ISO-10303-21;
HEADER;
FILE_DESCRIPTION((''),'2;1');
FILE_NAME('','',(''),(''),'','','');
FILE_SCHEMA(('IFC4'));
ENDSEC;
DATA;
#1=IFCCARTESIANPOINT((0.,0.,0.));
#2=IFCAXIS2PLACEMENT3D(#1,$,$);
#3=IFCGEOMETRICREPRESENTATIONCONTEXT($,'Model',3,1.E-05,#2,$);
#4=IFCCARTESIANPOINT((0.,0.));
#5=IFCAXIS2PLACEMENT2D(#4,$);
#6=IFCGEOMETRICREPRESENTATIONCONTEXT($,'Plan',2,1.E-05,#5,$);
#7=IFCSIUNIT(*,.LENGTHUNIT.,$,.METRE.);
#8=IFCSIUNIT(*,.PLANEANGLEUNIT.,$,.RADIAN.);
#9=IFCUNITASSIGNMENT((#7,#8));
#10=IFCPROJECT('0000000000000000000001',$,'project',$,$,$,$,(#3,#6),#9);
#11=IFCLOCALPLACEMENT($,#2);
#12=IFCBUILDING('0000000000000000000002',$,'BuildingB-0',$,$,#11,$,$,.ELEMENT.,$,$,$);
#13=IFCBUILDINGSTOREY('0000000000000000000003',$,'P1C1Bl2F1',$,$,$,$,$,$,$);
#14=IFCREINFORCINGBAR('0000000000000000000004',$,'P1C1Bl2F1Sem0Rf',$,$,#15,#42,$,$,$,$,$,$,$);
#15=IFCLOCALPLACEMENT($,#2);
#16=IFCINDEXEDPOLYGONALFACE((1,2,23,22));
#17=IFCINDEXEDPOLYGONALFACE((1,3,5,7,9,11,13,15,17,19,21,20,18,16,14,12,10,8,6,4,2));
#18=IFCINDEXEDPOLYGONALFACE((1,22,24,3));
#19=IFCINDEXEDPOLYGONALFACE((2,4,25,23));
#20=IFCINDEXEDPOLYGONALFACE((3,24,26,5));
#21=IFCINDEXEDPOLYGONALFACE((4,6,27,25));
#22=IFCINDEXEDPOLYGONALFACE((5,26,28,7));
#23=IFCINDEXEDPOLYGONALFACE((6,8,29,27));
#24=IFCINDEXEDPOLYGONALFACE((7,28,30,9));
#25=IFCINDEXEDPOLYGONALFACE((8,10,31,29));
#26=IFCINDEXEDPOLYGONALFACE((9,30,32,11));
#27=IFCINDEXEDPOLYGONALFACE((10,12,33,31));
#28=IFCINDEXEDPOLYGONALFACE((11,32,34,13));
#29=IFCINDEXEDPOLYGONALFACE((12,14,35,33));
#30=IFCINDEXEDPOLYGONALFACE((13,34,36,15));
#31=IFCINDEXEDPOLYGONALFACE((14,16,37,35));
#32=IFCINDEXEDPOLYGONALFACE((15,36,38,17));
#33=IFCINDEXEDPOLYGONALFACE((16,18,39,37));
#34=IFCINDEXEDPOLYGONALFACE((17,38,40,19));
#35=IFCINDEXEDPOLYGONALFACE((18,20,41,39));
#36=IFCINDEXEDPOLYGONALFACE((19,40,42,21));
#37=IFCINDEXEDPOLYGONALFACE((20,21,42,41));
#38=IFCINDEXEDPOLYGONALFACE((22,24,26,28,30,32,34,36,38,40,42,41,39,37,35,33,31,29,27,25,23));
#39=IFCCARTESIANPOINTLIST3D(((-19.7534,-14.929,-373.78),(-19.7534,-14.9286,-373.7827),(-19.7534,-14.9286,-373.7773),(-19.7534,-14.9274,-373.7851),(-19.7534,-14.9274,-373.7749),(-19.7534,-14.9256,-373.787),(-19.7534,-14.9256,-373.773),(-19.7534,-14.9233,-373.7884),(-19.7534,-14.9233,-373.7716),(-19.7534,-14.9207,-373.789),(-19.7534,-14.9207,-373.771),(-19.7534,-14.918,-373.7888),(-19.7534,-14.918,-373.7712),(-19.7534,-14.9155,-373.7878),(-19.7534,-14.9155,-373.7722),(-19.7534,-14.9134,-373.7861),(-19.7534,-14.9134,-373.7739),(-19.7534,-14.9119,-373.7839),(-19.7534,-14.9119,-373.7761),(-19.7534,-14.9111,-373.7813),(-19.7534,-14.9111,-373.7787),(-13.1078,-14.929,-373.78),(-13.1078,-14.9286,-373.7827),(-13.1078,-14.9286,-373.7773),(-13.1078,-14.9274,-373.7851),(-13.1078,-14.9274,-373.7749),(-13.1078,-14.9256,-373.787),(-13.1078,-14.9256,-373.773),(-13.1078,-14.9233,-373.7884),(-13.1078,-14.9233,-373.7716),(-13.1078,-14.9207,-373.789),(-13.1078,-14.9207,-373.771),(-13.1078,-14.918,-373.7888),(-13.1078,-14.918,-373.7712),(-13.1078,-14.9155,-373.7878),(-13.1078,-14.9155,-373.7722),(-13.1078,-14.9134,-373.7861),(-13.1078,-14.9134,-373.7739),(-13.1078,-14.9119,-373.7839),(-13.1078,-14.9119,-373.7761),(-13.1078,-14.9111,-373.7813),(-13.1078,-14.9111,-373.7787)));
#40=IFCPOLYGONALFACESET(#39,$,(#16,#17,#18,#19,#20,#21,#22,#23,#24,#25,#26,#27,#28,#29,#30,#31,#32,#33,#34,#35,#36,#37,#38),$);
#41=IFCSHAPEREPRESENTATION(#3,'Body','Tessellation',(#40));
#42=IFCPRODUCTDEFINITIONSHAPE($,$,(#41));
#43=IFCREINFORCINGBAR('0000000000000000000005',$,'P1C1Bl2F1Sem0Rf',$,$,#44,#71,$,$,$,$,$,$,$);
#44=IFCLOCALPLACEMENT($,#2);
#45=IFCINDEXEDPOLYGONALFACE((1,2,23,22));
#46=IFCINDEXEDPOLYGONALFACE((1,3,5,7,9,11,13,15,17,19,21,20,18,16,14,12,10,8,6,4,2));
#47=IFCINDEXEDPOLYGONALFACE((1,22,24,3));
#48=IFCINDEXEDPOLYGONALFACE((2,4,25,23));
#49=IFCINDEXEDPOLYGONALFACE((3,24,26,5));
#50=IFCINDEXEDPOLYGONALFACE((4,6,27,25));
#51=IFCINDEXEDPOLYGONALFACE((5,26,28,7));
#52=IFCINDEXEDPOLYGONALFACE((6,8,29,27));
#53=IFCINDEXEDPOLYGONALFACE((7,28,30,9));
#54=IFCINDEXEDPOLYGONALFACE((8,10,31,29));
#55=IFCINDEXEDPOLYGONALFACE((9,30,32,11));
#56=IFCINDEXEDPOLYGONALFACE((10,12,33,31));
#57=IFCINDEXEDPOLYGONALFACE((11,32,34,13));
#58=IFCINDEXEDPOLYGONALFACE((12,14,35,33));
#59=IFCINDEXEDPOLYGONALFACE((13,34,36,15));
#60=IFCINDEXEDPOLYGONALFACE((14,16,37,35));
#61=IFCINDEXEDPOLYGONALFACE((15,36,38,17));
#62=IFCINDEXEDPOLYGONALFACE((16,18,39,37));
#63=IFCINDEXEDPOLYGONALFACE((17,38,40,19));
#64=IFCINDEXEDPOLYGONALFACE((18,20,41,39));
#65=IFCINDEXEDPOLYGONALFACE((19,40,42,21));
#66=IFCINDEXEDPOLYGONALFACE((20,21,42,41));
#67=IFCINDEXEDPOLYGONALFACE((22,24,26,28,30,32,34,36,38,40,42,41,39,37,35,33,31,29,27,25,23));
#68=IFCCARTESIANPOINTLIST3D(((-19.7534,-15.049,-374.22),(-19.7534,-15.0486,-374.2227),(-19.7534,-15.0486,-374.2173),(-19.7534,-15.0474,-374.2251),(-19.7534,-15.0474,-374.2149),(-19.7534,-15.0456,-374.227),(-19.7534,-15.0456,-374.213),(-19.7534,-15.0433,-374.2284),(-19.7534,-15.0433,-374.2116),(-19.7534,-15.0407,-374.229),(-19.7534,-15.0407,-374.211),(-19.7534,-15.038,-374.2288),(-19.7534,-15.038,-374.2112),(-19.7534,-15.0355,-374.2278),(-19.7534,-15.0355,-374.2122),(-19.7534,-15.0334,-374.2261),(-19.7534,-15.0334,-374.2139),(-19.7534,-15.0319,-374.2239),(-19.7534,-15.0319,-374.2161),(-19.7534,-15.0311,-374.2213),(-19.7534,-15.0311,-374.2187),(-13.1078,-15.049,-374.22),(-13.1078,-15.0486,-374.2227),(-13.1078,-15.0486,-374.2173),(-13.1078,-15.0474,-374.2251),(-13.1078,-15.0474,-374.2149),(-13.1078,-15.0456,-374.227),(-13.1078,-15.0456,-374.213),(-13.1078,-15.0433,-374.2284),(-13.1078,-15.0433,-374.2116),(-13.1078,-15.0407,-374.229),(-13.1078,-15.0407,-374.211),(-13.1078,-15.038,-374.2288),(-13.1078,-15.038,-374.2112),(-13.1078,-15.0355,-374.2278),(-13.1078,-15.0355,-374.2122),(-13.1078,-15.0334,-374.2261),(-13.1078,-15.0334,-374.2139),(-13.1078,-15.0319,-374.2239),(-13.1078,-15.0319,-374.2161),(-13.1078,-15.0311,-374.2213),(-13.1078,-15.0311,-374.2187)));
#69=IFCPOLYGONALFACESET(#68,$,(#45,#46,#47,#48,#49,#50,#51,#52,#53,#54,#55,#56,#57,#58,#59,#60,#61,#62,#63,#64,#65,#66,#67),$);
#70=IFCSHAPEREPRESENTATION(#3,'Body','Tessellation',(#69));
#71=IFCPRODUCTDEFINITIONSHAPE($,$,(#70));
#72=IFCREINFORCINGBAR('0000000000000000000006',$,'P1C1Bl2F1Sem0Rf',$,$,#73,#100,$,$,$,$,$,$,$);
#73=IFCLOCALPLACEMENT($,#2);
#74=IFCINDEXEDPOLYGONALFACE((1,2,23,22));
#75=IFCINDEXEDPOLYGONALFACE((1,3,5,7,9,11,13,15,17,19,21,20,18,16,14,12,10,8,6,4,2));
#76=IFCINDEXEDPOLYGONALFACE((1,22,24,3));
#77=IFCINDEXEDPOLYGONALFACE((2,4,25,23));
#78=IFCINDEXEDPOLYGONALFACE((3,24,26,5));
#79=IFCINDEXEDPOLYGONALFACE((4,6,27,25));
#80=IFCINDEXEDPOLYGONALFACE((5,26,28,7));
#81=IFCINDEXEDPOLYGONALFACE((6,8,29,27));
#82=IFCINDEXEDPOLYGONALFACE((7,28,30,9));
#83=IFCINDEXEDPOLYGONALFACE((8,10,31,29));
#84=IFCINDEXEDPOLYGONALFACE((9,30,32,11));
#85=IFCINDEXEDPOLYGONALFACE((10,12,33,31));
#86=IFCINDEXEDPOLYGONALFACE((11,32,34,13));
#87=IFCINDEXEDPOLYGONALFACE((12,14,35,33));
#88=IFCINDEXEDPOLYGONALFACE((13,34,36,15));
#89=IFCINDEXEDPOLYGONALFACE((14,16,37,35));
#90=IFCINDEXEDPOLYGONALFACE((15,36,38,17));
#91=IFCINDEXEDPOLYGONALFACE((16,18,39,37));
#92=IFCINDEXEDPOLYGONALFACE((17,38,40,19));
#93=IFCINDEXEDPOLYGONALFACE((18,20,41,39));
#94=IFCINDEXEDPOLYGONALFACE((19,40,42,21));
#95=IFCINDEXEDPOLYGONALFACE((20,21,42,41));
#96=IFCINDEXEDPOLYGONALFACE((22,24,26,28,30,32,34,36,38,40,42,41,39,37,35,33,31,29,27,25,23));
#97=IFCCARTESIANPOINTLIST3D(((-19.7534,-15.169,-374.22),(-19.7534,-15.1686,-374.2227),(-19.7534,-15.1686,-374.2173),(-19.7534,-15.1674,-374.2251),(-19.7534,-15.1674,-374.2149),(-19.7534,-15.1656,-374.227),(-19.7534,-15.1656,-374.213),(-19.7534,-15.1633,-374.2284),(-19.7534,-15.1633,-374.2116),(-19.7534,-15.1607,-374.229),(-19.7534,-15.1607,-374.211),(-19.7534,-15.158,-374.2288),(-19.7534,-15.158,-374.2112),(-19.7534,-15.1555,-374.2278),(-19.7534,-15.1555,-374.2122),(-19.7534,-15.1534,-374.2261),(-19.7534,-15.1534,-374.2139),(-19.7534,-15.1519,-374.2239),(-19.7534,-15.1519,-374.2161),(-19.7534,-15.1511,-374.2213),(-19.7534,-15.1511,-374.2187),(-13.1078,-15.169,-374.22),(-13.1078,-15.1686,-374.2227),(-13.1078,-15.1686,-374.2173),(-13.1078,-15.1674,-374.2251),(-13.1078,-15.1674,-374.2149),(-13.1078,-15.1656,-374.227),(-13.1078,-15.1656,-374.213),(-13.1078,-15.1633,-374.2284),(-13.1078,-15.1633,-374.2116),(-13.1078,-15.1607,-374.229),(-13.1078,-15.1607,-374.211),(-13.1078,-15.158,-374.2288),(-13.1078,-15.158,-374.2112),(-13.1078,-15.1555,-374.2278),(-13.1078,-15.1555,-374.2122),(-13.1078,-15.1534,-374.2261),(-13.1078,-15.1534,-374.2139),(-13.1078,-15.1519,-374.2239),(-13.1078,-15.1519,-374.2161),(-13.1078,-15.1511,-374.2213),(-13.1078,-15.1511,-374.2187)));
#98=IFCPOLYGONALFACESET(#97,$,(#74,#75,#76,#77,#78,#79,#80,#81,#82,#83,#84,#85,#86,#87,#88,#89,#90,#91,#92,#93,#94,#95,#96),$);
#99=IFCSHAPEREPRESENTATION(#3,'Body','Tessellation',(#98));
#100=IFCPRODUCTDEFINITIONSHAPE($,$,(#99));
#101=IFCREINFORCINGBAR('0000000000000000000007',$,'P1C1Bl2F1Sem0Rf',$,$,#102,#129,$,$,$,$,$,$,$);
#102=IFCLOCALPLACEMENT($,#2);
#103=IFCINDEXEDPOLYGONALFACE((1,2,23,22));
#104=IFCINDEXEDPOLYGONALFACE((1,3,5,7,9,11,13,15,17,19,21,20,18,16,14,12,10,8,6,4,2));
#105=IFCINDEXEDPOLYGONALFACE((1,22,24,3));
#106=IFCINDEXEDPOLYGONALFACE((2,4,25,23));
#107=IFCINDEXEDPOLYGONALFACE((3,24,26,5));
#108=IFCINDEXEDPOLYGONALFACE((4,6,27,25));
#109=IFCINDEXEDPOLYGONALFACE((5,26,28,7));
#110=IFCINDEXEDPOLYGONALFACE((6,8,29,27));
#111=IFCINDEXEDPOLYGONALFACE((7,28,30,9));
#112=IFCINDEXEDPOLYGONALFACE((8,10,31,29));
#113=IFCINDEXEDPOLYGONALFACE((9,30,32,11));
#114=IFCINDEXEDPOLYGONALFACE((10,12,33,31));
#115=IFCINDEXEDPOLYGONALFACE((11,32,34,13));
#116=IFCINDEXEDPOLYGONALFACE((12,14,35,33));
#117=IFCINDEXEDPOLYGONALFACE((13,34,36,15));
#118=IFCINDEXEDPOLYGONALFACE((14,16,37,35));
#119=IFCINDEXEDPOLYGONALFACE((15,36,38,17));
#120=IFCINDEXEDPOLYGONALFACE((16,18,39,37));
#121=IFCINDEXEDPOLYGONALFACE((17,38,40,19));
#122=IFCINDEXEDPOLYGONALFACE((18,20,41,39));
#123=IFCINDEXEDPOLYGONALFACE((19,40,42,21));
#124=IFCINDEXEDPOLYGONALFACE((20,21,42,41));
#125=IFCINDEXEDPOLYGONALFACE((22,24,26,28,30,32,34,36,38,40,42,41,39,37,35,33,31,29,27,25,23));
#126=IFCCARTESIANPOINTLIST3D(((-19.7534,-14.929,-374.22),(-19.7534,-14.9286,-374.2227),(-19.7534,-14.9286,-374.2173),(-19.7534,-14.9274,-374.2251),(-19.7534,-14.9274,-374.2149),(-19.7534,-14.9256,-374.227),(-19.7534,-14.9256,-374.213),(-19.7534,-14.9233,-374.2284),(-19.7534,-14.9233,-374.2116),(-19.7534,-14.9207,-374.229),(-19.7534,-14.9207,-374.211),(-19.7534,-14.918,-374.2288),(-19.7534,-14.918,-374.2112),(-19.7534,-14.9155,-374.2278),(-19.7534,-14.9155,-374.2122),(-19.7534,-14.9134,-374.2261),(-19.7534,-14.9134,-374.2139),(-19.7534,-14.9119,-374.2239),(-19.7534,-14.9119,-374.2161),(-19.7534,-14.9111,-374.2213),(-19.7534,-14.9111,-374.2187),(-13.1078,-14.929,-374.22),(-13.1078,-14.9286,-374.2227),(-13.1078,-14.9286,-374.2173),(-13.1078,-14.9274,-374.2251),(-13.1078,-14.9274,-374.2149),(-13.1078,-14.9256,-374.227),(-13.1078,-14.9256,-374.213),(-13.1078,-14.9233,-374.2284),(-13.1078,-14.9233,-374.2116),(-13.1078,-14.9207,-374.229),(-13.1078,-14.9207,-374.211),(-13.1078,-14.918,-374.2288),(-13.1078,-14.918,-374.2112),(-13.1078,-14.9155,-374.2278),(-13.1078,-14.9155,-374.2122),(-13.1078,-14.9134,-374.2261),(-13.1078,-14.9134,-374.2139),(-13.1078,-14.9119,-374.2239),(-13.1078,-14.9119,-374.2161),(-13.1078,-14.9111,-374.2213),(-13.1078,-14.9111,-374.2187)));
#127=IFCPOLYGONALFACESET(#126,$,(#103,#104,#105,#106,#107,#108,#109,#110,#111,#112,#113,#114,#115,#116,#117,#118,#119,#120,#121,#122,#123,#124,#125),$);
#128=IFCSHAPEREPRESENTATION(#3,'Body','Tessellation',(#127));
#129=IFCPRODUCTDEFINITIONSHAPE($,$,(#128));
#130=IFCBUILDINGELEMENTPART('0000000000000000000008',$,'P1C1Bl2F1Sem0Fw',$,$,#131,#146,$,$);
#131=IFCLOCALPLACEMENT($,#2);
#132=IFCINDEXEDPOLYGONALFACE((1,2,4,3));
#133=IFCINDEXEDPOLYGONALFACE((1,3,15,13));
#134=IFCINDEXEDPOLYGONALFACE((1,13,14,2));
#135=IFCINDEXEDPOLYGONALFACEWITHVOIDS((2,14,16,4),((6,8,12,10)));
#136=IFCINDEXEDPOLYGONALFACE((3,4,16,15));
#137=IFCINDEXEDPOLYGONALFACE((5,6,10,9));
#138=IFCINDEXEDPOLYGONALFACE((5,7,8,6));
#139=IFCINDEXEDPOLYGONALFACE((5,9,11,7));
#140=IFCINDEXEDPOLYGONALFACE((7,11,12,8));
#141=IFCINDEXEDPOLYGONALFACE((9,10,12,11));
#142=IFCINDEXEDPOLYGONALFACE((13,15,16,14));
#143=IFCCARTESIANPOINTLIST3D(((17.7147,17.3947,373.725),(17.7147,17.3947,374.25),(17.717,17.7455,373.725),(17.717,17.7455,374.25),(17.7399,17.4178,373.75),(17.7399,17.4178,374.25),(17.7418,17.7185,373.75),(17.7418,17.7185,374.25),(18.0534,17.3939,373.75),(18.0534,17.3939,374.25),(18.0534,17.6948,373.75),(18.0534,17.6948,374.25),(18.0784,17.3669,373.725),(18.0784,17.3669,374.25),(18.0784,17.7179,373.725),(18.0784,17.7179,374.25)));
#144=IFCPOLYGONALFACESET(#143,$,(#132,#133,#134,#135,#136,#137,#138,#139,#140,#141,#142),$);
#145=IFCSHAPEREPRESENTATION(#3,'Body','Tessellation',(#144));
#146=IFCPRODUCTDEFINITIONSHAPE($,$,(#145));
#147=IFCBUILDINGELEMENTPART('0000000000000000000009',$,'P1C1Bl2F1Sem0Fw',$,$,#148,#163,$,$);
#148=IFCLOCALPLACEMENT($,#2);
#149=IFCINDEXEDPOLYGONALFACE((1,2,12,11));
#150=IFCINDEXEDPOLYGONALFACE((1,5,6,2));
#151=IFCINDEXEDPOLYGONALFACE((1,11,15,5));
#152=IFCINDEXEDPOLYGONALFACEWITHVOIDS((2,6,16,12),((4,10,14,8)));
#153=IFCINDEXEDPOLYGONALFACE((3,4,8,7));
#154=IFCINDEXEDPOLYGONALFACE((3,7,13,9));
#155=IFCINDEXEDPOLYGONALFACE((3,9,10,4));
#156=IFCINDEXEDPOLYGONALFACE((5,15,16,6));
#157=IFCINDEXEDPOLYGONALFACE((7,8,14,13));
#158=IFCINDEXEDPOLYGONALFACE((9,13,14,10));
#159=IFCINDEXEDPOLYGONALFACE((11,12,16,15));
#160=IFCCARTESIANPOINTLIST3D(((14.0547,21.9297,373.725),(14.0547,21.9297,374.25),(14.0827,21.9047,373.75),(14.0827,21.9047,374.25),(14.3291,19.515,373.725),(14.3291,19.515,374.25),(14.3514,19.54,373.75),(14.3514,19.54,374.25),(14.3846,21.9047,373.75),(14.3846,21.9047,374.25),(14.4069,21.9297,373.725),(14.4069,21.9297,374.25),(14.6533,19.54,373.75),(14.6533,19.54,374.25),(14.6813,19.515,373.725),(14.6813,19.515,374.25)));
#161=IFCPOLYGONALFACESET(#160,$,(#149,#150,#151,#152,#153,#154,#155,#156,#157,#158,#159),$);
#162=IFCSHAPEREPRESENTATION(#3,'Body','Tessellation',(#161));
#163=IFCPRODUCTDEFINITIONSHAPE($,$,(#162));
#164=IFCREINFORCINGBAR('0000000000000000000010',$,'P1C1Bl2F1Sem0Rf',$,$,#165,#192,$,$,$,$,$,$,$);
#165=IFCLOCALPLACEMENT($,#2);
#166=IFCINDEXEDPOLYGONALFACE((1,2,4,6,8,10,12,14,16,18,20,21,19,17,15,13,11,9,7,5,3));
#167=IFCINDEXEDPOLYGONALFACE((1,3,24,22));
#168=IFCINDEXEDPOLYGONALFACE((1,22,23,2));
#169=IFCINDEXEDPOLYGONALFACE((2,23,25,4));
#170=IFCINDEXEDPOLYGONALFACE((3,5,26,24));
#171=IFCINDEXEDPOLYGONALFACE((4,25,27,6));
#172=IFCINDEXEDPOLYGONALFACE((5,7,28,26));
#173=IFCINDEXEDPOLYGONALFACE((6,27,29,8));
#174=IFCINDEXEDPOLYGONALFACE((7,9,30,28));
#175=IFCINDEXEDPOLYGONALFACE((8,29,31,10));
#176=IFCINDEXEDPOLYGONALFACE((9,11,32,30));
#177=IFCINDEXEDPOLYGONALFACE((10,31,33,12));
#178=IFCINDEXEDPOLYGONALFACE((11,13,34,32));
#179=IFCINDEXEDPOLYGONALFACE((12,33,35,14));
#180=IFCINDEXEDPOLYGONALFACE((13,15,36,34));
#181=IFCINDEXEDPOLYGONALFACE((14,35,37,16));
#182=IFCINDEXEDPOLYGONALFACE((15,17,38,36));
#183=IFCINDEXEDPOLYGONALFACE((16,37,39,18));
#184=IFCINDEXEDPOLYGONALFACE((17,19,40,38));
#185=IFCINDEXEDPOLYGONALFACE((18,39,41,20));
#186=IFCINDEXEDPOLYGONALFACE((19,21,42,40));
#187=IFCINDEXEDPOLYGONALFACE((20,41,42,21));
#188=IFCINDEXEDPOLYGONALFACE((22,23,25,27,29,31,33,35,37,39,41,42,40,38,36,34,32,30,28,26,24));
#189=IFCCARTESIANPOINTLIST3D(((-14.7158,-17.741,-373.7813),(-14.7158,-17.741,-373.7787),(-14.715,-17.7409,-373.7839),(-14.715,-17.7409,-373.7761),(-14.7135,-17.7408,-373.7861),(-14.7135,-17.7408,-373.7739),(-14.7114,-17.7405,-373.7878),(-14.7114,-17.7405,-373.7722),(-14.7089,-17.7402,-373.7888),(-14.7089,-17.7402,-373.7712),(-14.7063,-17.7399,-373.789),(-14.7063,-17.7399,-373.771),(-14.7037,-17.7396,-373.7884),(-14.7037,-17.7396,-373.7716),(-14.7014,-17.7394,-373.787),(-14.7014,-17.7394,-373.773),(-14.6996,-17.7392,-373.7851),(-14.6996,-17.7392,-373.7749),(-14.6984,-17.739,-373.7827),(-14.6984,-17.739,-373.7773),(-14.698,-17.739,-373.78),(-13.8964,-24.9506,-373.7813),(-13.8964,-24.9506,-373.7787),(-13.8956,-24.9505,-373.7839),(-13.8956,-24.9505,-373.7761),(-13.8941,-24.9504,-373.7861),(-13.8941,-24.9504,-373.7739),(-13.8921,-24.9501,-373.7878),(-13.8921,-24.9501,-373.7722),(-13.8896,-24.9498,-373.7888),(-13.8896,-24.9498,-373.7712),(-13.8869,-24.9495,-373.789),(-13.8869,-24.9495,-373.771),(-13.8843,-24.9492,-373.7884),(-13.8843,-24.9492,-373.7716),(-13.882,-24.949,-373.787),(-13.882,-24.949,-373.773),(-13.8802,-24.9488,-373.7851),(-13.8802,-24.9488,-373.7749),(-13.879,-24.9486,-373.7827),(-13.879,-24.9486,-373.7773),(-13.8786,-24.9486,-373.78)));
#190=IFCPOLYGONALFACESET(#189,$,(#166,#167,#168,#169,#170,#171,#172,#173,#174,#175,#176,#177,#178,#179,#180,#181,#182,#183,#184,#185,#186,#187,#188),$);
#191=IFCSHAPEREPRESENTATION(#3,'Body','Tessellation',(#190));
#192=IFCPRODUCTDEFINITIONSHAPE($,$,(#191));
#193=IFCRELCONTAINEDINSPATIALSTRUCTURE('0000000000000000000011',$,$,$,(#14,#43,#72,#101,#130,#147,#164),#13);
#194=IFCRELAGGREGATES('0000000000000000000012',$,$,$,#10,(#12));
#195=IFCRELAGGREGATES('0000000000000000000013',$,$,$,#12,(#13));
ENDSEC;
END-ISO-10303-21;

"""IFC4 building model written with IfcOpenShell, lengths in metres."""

from ifc_helpers import new_model, entity, si_unit, origin, origin_2d, place, context, project, spatial, polyline, outline, extrude, element, save


model = new_model("IFC4")

# Units and contexts
model_context = context("Model", 3, precision=1e-05, world=origin())
plan_context = context("Plan", 2, precision=1e-05, world=origin_2d())
ifc_project = project(units=[si_unit("LENGTHUNIT", "METRE"), si_unit("PLANEANGLEUNIT", "RADIAN")], contexts=[model_context, plan_context])

# Building, storey
building_placement = place(None, origin())
building = spatial("IfcBuilding", under=ifc_project, at=building_placement, Name="BuildingB-0", CompositionType="ELEMENT")
storey = spatial("IfcBuildingStorey", under=building, Name="P1C1Bl2F1")

# Reinforcing bars
element("IfcReinforcingBar", 1, inside=storey, Name="P1C1Bl2F1Sem0Rf", context=model_context, shape_type="SweptSolid", body=[
    entity("IfcSurfaceCurveSweptAreaSolid", entity("IfcCircleProfileDef", "AREA", None, None, 0.009), None, entity("IfcPolyline", [entity("IfcCartesianPoint", [19.7534, 14.92, 373.78]), entity("IfcCartesianPoint", [13.1078, 14.92, 373.78])]), None, None, entity("IfcPlane", entity("IfcAxis2Placement3D", entity("IfcCartesianPoint", [19.7534, 14.92, 373.78]), entity("IfcDirection", [0.0, 0.0, 1.0]), entity("IfcDirection", [1.0, 0.0, 0.0])))),
])
element("IfcReinforcingBar", 2, inside=storey, Name="P1C1Bl2F1Sem0Rf", context=model_context, shape_type="SweptSolid", body=[
    entity("IfcSurfaceCurveSweptAreaSolid", entity("IfcCircleProfileDef", "AREA", None, None, 0.009), None, entity("IfcPolyline", [entity("IfcCartesianPoint", [19.7534, 15.04, 374.22]), entity("IfcCartesianPoint", [13.1078, 15.04, 374.22])]), None, None, entity("IfcPlane", entity("IfcAxis2Placement3D", entity("IfcCartesianPoint", [19.7534, 15.04, 374.22]), entity("IfcDirection", [0.0, 0.0, 1.0]), entity("IfcDirection", [1.0, 0.0, 0.0])))),
])
element("IfcReinforcingBar", 3, inside=storey, Name="P1C1Bl2F1Sem0Rf", context=model_context, shape_type="SweptSolid", body=[
    entity("IfcSurfaceCurveSweptAreaSolid", entity("IfcCircleProfileDef", "AREA", None, None, 0.009), None, entity("IfcPolyline", [entity("IfcCartesianPoint", [19.7534, 15.16, 374.22]), entity("IfcCartesianPoint", [13.1078, 15.16, 374.22])]), None, None, entity("IfcPlane", entity("IfcAxis2Placement3D", entity("IfcCartesianPoint", [19.7534, 15.16, 374.22]), entity("IfcDirection", [0.0, 0.0, 1.0]), entity("IfcDirection", [1.0, 0.0, 0.0])))),
])
element("IfcReinforcingBar", 4, inside=storey, Name="P1C1Bl2F1Sem0Rf", context=model_context, shape_type="SweptSolid", body=[
    entity("IfcSurfaceCurveSweptAreaSolid", entity("IfcCircleProfileDef", "AREA", None, None, 0.009), None, entity("IfcPolyline", [entity("IfcCartesianPoint", [19.7534, 14.92, 374.22]), entity("IfcCartesianPoint", [13.1078, 14.92, 374.22])]), None, None, entity("IfcPlane", entity("IfcAxis2Placement3D", entity("IfcCartesianPoint", [19.7534, 14.92, 374.22]), entity("IfcDirection", [0.0, 0.0, 1.0]), entity("IfcDirection", [1.0, 0.0, 0.0])))),
])

# Building element parts, openings
building_element_part_1 = element("IfcBuildingElementPart", 5, inside=storey, Name="P1C1Bl2F1Sem0Fw", context=model_context, shape_type="SweptSolid", body=[
    extrude(outline(polyline([(17.7147, 17.3947, 373.725), (18.0784, 17.3669, 373.725), (18.0784, 17.7179, 373.725), (17.717, 17.7455, 373.725), (17.7147, 17.3947, 373.725)])), None, (0.0, 0.0, 1.0), 0.525),
])
element("IfcOpeningElement", 6, inside=storey, cuts=building_element_part_1, context=model_context, shape_type="SweptSolid", body=[
    extrude(outline(polyline([(17.7399, 17.4178, 373.75), (18.0534, 17.3939, 373.75), (18.0534, 17.6948, 373.75), (17.7418, 17.7185, 373.75), (17.7399, 17.4178, 373.75)])), None, (0.0, 0.0, 1.0), 0.5),
])
building_element_part_2 = element("IfcBuildingElementPart", 7, inside=storey, Name="P1C1Bl2F1Sem0Fw", context=model_context, shape_type="SweptSolid", body=[
    extrude(outline(polyline([(14.3291, 19.515, 373.725), (14.6813, 19.515, 373.725), (14.4069, 21.9297, 373.725), (14.0547, 21.9297, 373.725), (14.3291, 19.515, 373.725)])), None, (0.0, 0.0, 1.0), 0.525),
])
element("IfcOpeningElement", 8, inside=storey, cuts=building_element_part_2, context=model_context, shape_type="SweptSolid", body=[
    extrude(outline(polyline([(14.3514, 19.54, 373.75), (14.6533, 19.54, 373.75), (14.3846, 21.9047, 373.75), (14.0827, 21.9047, 373.75), (14.3514, 19.54, 373.75)])), None, (0.0, 0.0, 1.0), 0.5),
])

# Reinforcing bar
element("IfcReinforcingBar", 9, inside=storey, Name="P1C1Bl2F1Sem0Rf", context=model_context, shape_type="SweptSolid", body=[
    entity("IfcSurfaceCurveSweptAreaSolid", entity("IfcCircleProfileDef", "AREA", None, None, 0.009), None, entity("IfcPolyline", [entity("IfcCartesianPoint", [14.7069, 17.74, 373.78]), entity("IfcCartesianPoint", [13.8876, 24.9496, 373.78])]), None, None, entity("IfcPlane", entity("IfcAxis2Placement3D", entity("IfcCartesianPoint", [14.7069, 17.74, 373.78]), entity("IfcDirection", [0.0, 0.0, 1.0]), entity("IfcDirection", [1.0, 0.0, 0.0])))),
])

save(model, "model.ifc")
